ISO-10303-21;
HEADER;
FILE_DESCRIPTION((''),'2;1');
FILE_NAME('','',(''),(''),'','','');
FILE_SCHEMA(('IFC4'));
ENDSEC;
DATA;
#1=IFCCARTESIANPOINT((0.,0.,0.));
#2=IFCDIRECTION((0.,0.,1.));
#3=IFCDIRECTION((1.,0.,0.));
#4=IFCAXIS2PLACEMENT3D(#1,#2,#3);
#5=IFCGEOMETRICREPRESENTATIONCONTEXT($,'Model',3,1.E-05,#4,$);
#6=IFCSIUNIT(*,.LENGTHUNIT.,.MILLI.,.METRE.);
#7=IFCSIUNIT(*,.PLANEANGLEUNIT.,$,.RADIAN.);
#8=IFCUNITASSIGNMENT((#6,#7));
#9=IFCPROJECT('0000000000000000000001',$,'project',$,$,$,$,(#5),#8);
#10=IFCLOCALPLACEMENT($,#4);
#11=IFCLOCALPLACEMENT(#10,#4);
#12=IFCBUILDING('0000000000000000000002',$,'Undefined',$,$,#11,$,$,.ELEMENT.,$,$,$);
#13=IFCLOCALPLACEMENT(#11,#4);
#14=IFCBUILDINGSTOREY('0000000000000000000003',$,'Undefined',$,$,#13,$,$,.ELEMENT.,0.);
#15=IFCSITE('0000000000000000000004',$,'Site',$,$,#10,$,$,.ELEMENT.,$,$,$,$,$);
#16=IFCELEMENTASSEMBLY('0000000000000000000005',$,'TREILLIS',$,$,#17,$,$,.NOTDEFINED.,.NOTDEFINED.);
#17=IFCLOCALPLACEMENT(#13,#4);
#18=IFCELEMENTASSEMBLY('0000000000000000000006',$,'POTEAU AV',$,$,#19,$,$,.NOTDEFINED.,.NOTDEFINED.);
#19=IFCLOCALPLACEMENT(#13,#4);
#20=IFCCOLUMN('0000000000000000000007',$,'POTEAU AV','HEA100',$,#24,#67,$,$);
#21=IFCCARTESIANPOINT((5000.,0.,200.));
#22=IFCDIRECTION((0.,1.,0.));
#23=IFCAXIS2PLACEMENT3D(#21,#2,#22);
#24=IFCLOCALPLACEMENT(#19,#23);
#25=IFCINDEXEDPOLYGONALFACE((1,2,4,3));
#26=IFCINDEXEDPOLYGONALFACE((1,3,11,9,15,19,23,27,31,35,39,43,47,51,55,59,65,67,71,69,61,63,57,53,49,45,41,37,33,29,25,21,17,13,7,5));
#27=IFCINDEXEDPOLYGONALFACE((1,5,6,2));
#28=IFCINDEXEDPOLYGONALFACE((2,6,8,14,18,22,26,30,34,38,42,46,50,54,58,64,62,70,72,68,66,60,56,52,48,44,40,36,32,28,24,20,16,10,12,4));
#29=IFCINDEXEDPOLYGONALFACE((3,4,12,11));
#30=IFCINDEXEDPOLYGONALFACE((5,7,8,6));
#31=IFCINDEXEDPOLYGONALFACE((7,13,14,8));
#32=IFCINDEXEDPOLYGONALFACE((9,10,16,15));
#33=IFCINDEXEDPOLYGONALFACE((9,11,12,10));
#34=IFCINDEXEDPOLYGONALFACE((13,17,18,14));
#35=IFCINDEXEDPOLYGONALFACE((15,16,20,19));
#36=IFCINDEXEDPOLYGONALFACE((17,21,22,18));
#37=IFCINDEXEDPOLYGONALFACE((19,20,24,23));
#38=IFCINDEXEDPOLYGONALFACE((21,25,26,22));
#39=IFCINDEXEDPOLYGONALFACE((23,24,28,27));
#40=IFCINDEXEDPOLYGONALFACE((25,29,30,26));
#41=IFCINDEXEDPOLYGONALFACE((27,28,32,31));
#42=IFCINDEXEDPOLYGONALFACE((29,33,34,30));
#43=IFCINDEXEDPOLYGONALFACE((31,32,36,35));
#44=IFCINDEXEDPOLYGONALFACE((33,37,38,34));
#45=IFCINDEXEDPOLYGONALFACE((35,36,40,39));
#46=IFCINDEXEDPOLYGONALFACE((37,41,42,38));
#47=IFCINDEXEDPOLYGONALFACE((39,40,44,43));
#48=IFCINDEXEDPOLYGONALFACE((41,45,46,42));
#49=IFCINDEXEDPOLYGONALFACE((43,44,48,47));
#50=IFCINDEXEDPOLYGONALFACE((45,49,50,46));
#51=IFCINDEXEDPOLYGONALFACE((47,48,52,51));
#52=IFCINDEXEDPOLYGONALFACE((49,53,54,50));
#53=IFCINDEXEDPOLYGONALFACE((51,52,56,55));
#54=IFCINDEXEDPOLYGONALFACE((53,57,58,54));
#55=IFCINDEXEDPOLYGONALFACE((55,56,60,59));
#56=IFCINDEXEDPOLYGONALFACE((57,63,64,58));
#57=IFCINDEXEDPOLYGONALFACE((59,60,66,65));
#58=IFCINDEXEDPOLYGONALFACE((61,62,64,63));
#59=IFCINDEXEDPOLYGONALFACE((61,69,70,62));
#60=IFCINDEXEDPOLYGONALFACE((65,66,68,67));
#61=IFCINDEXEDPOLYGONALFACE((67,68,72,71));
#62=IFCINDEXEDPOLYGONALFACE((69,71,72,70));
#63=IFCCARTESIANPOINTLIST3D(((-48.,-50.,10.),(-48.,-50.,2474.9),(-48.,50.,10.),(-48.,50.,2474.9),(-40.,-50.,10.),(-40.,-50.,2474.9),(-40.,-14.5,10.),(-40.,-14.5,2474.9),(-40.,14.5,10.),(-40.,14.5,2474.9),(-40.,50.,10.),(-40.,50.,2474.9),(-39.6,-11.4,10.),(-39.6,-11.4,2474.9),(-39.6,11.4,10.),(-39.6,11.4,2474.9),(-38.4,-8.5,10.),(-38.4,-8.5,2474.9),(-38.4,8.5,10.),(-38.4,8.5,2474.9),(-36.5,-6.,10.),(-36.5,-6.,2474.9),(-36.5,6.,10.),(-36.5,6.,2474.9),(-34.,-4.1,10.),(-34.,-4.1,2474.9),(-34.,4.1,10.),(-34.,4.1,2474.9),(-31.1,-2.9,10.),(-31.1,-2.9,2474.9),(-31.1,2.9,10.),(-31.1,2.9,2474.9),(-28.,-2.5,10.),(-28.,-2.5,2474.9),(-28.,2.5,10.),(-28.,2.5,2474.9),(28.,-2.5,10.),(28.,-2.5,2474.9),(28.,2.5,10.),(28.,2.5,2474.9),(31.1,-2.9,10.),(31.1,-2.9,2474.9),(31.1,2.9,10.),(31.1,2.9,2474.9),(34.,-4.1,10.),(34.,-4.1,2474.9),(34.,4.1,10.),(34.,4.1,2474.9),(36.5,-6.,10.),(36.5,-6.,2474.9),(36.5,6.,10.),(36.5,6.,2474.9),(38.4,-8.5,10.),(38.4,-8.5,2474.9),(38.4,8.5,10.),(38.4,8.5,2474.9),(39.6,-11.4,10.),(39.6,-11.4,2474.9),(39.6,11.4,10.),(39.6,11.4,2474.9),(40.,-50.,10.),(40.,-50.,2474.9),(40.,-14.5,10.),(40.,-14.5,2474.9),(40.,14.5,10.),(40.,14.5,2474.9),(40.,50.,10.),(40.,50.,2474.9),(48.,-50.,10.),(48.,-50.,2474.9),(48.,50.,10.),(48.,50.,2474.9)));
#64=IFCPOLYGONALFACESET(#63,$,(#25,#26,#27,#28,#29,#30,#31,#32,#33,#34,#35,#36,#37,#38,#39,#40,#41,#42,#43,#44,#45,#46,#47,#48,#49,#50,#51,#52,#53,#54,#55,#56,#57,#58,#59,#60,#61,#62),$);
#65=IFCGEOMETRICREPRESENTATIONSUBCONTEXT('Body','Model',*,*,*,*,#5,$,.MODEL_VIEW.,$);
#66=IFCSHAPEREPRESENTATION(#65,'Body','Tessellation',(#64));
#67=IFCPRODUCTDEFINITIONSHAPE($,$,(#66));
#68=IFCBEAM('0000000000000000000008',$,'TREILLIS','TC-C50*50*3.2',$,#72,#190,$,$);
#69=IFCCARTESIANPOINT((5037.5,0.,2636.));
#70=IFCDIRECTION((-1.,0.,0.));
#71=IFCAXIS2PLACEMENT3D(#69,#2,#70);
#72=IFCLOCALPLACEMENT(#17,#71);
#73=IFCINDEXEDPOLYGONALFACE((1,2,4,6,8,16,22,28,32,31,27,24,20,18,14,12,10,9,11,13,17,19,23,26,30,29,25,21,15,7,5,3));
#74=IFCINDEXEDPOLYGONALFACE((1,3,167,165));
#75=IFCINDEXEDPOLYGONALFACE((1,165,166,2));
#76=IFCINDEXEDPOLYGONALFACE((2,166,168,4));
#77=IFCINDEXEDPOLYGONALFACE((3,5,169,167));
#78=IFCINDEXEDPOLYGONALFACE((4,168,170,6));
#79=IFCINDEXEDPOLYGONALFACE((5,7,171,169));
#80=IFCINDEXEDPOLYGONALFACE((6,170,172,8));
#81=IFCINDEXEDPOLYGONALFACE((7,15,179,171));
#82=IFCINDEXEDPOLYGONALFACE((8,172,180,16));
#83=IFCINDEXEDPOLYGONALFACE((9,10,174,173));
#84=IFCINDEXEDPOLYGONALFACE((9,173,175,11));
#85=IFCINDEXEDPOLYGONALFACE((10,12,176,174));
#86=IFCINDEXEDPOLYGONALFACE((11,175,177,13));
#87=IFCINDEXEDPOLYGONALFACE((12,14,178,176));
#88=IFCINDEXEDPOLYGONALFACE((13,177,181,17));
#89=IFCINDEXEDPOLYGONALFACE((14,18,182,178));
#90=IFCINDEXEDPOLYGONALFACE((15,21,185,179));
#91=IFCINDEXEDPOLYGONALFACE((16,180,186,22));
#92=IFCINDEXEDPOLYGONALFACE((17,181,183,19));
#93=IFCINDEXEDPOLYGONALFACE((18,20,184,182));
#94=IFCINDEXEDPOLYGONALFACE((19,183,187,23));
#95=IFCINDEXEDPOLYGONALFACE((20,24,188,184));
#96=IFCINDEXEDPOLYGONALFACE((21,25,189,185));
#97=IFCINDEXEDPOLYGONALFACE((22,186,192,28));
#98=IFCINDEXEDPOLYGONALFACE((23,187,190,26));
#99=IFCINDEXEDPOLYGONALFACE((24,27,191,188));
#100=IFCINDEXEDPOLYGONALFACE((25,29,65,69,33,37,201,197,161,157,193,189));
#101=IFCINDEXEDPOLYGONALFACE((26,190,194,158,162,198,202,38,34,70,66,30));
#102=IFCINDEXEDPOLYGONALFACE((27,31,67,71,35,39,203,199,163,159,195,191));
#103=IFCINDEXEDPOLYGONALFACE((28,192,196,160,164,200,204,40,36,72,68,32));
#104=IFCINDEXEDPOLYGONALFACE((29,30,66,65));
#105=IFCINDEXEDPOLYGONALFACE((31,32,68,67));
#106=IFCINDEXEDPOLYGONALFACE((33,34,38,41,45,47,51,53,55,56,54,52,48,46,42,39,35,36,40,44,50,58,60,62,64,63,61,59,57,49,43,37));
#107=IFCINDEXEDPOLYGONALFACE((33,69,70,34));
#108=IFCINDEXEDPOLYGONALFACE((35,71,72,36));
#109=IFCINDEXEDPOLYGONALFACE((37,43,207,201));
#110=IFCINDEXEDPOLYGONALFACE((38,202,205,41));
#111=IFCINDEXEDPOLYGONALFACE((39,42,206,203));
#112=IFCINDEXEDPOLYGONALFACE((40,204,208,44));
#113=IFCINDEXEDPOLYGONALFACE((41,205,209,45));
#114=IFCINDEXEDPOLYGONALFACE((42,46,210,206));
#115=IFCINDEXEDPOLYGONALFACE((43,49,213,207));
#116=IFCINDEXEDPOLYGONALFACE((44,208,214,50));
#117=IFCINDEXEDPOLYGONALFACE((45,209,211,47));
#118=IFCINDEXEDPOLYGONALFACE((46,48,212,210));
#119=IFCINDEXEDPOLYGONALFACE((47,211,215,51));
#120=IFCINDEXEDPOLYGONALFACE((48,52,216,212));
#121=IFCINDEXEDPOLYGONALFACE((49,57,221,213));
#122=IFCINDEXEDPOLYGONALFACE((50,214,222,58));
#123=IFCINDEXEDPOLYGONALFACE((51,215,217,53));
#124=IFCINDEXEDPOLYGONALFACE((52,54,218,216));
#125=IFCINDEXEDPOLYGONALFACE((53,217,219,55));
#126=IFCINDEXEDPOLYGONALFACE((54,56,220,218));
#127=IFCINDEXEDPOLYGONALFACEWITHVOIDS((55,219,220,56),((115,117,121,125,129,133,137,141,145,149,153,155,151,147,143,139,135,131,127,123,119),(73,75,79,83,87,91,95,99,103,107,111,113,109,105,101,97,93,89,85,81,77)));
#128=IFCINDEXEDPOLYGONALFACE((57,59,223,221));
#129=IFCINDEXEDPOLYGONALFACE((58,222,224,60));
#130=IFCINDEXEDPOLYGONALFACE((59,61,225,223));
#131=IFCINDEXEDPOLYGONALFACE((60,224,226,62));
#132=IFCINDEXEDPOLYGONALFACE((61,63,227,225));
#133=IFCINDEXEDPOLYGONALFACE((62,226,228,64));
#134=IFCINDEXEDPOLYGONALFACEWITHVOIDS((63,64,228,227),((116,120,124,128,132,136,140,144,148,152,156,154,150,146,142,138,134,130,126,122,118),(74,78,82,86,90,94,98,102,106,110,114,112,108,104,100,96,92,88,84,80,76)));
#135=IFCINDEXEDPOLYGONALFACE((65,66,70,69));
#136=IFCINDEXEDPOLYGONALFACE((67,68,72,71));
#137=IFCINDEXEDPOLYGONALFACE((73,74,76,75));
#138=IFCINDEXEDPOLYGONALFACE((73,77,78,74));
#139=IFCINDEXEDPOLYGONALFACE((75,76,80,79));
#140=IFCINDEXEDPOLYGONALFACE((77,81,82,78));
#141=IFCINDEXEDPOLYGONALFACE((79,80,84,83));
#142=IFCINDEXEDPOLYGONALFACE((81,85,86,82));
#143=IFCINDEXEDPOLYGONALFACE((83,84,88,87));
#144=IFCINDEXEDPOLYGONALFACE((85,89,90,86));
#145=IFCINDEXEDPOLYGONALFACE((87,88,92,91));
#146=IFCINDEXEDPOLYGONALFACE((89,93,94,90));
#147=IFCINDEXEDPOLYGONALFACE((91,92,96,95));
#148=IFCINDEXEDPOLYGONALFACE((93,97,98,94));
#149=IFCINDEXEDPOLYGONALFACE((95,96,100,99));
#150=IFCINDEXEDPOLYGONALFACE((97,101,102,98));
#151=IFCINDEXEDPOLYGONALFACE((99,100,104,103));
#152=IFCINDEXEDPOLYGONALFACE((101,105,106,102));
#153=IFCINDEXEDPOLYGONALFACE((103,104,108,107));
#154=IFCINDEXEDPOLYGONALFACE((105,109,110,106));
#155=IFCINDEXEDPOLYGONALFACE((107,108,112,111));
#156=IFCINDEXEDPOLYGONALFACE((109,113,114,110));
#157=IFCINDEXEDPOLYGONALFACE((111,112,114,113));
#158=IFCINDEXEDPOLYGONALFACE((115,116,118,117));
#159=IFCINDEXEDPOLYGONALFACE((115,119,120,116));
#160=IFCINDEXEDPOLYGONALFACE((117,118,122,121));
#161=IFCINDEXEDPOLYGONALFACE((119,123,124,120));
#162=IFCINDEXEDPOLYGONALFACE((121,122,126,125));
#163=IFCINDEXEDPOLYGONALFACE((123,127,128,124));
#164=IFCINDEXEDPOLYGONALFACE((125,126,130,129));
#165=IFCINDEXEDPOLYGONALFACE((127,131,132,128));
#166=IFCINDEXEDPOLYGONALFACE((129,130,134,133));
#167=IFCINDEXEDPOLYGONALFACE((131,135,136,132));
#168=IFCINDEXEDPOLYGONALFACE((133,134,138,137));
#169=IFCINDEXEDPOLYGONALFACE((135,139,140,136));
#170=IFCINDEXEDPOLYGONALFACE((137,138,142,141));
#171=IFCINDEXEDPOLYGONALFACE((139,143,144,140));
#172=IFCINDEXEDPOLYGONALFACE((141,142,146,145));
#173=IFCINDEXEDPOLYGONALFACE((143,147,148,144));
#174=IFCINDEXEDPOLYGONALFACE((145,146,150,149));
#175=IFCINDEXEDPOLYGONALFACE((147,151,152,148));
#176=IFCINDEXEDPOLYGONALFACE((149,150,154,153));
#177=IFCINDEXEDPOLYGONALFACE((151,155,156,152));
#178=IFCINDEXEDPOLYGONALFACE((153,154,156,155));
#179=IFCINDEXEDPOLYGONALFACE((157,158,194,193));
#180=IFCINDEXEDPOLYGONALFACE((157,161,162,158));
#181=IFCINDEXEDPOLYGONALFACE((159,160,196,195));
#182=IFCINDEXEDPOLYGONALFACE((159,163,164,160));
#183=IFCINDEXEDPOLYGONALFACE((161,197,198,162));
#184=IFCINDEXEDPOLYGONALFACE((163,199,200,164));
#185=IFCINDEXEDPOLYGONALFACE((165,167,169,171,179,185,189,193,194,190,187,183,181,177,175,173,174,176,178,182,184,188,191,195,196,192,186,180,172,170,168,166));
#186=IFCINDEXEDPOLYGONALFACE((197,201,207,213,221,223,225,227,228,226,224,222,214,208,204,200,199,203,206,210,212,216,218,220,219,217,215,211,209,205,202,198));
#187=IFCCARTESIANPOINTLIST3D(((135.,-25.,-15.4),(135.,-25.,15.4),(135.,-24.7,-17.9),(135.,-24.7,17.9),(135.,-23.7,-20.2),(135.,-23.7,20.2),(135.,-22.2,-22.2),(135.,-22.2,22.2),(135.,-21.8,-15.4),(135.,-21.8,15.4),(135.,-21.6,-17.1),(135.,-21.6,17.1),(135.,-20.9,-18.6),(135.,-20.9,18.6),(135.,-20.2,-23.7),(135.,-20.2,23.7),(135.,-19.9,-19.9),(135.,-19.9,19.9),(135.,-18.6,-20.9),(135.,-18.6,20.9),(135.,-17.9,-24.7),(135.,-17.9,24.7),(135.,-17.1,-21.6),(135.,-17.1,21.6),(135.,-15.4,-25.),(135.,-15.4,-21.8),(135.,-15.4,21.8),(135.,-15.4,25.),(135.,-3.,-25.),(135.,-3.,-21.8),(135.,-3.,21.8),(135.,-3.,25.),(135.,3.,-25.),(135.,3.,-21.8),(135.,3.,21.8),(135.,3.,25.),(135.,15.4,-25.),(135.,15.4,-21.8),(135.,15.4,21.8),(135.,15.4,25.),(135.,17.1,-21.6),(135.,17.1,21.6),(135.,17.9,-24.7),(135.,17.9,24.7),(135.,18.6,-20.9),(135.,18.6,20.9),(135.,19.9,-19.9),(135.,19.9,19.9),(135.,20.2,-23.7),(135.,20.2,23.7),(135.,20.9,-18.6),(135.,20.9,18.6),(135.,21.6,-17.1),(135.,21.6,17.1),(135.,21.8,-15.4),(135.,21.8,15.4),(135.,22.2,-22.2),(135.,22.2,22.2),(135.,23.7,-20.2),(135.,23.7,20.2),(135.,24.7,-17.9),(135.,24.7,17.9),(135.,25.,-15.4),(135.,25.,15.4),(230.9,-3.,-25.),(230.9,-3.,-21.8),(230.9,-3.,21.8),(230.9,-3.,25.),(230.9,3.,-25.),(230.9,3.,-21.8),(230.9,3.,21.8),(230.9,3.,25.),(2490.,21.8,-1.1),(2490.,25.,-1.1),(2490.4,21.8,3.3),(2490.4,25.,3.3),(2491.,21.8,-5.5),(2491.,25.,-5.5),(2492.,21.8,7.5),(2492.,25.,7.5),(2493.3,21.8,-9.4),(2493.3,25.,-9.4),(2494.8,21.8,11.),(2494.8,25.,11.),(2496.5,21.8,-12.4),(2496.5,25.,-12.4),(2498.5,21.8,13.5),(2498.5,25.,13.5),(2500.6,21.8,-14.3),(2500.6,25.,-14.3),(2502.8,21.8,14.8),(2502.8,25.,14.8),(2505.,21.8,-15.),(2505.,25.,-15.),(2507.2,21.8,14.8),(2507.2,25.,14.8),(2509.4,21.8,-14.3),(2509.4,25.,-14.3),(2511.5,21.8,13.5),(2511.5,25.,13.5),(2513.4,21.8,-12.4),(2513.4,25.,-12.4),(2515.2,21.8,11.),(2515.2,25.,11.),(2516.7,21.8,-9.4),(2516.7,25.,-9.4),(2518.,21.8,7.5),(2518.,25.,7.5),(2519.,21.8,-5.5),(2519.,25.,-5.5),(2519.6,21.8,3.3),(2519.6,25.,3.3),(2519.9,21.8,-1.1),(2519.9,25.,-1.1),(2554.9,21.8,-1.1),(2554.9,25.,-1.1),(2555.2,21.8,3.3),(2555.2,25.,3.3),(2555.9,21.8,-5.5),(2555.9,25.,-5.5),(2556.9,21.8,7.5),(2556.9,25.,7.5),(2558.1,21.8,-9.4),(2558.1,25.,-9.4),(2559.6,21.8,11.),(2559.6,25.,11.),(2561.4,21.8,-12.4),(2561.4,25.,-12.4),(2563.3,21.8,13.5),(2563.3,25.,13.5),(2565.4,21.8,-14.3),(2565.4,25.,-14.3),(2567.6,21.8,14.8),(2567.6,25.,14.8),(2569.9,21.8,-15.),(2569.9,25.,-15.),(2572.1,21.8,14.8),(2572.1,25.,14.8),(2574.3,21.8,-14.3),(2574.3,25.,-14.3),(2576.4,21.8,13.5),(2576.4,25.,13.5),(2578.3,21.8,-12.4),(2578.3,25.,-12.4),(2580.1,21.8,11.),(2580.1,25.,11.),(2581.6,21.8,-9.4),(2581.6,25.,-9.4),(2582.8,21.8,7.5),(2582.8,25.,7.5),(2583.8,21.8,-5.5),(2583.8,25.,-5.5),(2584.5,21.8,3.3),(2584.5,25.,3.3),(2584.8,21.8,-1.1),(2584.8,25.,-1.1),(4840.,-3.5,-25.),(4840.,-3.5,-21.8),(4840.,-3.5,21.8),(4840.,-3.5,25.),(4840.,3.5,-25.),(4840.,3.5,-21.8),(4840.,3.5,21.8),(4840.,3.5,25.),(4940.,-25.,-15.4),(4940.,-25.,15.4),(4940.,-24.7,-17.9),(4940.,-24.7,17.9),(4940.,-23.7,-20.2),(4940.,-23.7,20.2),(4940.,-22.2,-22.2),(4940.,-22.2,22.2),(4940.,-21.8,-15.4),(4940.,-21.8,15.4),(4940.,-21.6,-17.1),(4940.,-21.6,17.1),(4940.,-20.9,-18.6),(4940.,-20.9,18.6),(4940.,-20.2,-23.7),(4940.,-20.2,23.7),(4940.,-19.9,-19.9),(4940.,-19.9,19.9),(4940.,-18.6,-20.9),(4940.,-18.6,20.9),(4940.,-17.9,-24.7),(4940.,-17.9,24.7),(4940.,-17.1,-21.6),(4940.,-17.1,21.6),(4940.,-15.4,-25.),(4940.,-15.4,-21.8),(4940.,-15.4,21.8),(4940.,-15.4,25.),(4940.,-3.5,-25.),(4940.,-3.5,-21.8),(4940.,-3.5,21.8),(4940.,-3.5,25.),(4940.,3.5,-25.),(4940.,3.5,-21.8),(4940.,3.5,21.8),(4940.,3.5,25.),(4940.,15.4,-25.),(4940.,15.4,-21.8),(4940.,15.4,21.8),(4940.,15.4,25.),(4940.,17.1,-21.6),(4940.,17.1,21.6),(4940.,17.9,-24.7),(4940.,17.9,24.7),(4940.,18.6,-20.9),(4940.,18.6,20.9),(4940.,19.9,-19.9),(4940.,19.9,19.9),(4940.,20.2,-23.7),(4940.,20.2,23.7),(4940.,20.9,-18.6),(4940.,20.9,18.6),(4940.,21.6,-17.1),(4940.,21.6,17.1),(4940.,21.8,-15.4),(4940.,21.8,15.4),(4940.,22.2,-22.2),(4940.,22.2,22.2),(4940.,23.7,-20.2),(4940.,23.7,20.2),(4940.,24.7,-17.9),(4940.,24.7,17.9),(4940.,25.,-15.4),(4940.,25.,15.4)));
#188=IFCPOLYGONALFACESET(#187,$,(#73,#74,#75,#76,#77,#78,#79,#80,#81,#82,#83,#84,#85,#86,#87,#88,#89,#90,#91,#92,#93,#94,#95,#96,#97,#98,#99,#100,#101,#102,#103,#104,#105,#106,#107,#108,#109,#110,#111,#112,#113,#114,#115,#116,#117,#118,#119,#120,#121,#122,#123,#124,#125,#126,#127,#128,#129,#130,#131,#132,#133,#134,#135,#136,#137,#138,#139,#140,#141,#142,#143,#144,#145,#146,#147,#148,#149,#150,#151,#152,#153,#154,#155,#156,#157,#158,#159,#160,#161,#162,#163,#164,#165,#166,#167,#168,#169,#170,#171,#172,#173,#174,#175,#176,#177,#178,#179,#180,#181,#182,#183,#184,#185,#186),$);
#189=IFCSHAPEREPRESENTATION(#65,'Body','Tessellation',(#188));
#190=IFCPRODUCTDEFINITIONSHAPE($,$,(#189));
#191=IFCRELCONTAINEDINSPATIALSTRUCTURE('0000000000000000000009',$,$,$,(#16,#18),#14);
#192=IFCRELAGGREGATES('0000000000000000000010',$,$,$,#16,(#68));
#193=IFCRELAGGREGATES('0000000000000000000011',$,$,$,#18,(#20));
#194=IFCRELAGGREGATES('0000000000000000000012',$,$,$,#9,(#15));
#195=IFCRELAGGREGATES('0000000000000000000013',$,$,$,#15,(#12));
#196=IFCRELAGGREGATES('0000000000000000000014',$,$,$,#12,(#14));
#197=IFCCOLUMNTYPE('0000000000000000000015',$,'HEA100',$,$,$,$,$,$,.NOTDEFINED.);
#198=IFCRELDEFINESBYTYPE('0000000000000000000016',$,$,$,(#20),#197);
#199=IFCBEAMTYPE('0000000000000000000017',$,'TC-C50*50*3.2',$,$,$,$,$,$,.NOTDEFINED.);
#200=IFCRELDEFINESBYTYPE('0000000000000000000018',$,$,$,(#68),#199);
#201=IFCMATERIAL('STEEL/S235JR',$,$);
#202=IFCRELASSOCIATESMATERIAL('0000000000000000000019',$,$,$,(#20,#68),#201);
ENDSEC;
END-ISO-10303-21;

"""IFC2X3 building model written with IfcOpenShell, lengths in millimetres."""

from ifc_helpers import new_model, si_unit, frame, origin_with_axes, origin_2d_with_axis, place, context, subcontext, project, spatial, rectangle, hollow_rectangle, circle, i_section, extrude, boolean, clip, halfspace, material, type_object, element, aggregate, save


model = new_model("IFC2X3")

# Units and contexts
model_context = context("Model", 3, precision=1e-05, world=origin_with_axes())
body_context = subcontext(model_context, "Body", "Model", "MODEL_VIEW")
ifc_project = project(units=[si_unit("LENGTHUNIT", "METRE", prefix="MILLI"), si_unit("PLANEANGLEUNIT", "RADIAN")], contexts=[model_context])

# Site, building, storey
site_placement = place(None, origin_with_axes())
site = spatial("IfcSite", under=ifc_project, at=site_placement, Name="Site", CompositionType="ELEMENT")
building_placement = place(site_placement, origin_with_axes())
building = spatial("IfcBuilding", under=site, at=building_placement, Name="Undefined", CompositionType="ELEMENT")
storey_placement = place(building_placement, origin_with_axes())
storey = spatial("IfcBuildingStorey", under=building, at=storey_placement, Name="Undefined", CompositionType="ELEMENT", Elevation=0.0)

# Element assemblies, column
ifc_material_1 = material(Name="STEEL/S235JR")
assembly_1_placement = place(storey_placement, origin_with_axes())
assembly_1 = element("IfcElementAssembly", 1, at=assembly_1_placement, inside=storey, Name="TREILLIS", AssemblyPlace="NOTDEFINED", PredefinedType="NOTDEFINED")
assembly_2_placement = place(storey_placement, origin_with_axes())
assembly_2 = element("IfcElementAssembly", 2, at=assembly_2_placement, inside=storey, Name="POTEAU AV", AssemblyPlace="NOTDEFINED", PredefinedType="NOTDEFINED")
column_type_1 = type_object("IfcColumnType", Name="HEA100", PredefinedType="NOTDEFINED")
column_1_placement = place(assembly_2_placement, frame((5000.0, 0.0, 200.0), z_axis=(0.0, 0.0, 1.0), x_axis=(0.0, 1.0, 0.0)))
column_1 = element("IfcColumn", 3, at=column_1_placement, type_object=column_type_1, material=ifc_material_1, Name="POTEAU AV", Description="HEA100", context=body_context, shape_type="Clipping", body=[
    clip(clip(extrude(i_section(OverallWidth=100.0, OverallDepth=96.0, WebThickness=5.0, FlangeThickness=8.0, FilletRadius=12.0, at=origin_2d_with_axis()), frame((0.0, 0.0, 2500.0), z_axis=(0.0, 0.0, -1.0), x_axis=(0.0, 1.0, 0.0)), (0.0, 0.0, 1.0), 2500.0), halfspace(frame((-48.0, 0.0, 2474.9), z_axis=(0.0, 0.0, -1.0), x_axis=(0.0, -1.0, 0.0)), True)), halfspace(frame((-48.0, 0.0, 10.0), z_axis=(0.0, 0.0, 1.0), x_axis=(0.0, 1.0, 0.0)), True)),
])

# Beam
beam_type_1 = type_object("IfcBeamType", Name="TC-C50*50*3.2", PredefinedType="NOTDEFINED")
beam_1_placement = place(assembly_1_placement, frame((5037.5, 0.0, 2636.0), z_axis=(0.0, 0.0, 1.0), x_axis=(-1.0, 0.0, 0.0)))
beam_1 = element("IfcBeam", 4, at=beam_1_placement, type_object=beam_type_1, material=ifc_material_1, Name="TREILLIS", Description="TC-C50*50*3.2", context=body_context, shape_type="CSG", body=[
    boolean("DIFFERENCE", boolean("DIFFERENCE", boolean("DIFFERENCE", boolean("DIFFERENCE", boolean("DIFFERENCE", boolean("DIFFERENCE", boolean("DIFFERENCE", extrude(hollow_rectangle(XDim=50.0, YDim=50.0, WallThickness=3.2, InnerFilletRadius=6.4, OuterFilletRadius=9.6, at=origin_2d_with_axis()), frame((4940.0, 0.0, 0.0), z_axis=(-1.0, 0.0, 0.0), x_axis=(0.0, -1.0, 0.0)), (0.0, 0.0, 1.0), 4940.0), extrude(rectangle(XDim=6.0, YDim=100.0, at=origin_2d_with_axis()), frame((4844.1, 0.0, -20.0), z_axis=(1.0, 0.0, 0.0), x_axis=(0.0, 1.0, 0.0)), (0.0, 0.0, 1.0), 149.9)), extrude(rectangle(XDim=6.0, YDim=100.0, at=origin_2d_with_axis()), frame((230.9, 0.0, -20.0), z_axis=(-1.0, 0.0, 0.0), x_axis=(0.0, -1.0, 0.0)), (0.0, 0.0, 1.0), 149.9)), extrude(circle(Radius=15.0, at=origin_2d_with_axis()), frame((2505.0, -5.0, 0.0), z_axis=(0.0, 1.0, 0.0), x_axis=(0.0, 0.0, -1.0)), (0.0, 0.0, 1.0), 49.0)), extrude(circle(Radius=15.0, at=origin_2d_with_axis()), frame((2569.9, -5.0, 0.0), z_axis=(0.0, 1.0, 0.0), x_axis=(0.0, 0.0, -1.0)), (0.0, 0.0, 1.0), 49.0)), extrude(rectangle(XDim=7.0, YDim=60.0, at=origin_2d_with_axis()), frame((4840.0, 0.0, 0.0), z_axis=(1.0, 0.0, 0.0), x_axis=(0.0, 1.0, 0.0)), (0.0, 0.0, 1.0), 154.0)), halfspace(frame((135.0, 25.0, -25.0), z_axis=(-1.0, 0.0, 0.0), x_axis=(0.0, 0.0, 1.0)), False)), halfspace(frame((4940.0, -25.0, -25.0), z_axis=(1.0, 0.0, 0.0), x_axis=(0.0, 0.0, 1.0)), False)),
])

aggregate(assembly_1, [beam_1])

aggregate(assembly_2, [column_1])

save(model, "model.ifc")
